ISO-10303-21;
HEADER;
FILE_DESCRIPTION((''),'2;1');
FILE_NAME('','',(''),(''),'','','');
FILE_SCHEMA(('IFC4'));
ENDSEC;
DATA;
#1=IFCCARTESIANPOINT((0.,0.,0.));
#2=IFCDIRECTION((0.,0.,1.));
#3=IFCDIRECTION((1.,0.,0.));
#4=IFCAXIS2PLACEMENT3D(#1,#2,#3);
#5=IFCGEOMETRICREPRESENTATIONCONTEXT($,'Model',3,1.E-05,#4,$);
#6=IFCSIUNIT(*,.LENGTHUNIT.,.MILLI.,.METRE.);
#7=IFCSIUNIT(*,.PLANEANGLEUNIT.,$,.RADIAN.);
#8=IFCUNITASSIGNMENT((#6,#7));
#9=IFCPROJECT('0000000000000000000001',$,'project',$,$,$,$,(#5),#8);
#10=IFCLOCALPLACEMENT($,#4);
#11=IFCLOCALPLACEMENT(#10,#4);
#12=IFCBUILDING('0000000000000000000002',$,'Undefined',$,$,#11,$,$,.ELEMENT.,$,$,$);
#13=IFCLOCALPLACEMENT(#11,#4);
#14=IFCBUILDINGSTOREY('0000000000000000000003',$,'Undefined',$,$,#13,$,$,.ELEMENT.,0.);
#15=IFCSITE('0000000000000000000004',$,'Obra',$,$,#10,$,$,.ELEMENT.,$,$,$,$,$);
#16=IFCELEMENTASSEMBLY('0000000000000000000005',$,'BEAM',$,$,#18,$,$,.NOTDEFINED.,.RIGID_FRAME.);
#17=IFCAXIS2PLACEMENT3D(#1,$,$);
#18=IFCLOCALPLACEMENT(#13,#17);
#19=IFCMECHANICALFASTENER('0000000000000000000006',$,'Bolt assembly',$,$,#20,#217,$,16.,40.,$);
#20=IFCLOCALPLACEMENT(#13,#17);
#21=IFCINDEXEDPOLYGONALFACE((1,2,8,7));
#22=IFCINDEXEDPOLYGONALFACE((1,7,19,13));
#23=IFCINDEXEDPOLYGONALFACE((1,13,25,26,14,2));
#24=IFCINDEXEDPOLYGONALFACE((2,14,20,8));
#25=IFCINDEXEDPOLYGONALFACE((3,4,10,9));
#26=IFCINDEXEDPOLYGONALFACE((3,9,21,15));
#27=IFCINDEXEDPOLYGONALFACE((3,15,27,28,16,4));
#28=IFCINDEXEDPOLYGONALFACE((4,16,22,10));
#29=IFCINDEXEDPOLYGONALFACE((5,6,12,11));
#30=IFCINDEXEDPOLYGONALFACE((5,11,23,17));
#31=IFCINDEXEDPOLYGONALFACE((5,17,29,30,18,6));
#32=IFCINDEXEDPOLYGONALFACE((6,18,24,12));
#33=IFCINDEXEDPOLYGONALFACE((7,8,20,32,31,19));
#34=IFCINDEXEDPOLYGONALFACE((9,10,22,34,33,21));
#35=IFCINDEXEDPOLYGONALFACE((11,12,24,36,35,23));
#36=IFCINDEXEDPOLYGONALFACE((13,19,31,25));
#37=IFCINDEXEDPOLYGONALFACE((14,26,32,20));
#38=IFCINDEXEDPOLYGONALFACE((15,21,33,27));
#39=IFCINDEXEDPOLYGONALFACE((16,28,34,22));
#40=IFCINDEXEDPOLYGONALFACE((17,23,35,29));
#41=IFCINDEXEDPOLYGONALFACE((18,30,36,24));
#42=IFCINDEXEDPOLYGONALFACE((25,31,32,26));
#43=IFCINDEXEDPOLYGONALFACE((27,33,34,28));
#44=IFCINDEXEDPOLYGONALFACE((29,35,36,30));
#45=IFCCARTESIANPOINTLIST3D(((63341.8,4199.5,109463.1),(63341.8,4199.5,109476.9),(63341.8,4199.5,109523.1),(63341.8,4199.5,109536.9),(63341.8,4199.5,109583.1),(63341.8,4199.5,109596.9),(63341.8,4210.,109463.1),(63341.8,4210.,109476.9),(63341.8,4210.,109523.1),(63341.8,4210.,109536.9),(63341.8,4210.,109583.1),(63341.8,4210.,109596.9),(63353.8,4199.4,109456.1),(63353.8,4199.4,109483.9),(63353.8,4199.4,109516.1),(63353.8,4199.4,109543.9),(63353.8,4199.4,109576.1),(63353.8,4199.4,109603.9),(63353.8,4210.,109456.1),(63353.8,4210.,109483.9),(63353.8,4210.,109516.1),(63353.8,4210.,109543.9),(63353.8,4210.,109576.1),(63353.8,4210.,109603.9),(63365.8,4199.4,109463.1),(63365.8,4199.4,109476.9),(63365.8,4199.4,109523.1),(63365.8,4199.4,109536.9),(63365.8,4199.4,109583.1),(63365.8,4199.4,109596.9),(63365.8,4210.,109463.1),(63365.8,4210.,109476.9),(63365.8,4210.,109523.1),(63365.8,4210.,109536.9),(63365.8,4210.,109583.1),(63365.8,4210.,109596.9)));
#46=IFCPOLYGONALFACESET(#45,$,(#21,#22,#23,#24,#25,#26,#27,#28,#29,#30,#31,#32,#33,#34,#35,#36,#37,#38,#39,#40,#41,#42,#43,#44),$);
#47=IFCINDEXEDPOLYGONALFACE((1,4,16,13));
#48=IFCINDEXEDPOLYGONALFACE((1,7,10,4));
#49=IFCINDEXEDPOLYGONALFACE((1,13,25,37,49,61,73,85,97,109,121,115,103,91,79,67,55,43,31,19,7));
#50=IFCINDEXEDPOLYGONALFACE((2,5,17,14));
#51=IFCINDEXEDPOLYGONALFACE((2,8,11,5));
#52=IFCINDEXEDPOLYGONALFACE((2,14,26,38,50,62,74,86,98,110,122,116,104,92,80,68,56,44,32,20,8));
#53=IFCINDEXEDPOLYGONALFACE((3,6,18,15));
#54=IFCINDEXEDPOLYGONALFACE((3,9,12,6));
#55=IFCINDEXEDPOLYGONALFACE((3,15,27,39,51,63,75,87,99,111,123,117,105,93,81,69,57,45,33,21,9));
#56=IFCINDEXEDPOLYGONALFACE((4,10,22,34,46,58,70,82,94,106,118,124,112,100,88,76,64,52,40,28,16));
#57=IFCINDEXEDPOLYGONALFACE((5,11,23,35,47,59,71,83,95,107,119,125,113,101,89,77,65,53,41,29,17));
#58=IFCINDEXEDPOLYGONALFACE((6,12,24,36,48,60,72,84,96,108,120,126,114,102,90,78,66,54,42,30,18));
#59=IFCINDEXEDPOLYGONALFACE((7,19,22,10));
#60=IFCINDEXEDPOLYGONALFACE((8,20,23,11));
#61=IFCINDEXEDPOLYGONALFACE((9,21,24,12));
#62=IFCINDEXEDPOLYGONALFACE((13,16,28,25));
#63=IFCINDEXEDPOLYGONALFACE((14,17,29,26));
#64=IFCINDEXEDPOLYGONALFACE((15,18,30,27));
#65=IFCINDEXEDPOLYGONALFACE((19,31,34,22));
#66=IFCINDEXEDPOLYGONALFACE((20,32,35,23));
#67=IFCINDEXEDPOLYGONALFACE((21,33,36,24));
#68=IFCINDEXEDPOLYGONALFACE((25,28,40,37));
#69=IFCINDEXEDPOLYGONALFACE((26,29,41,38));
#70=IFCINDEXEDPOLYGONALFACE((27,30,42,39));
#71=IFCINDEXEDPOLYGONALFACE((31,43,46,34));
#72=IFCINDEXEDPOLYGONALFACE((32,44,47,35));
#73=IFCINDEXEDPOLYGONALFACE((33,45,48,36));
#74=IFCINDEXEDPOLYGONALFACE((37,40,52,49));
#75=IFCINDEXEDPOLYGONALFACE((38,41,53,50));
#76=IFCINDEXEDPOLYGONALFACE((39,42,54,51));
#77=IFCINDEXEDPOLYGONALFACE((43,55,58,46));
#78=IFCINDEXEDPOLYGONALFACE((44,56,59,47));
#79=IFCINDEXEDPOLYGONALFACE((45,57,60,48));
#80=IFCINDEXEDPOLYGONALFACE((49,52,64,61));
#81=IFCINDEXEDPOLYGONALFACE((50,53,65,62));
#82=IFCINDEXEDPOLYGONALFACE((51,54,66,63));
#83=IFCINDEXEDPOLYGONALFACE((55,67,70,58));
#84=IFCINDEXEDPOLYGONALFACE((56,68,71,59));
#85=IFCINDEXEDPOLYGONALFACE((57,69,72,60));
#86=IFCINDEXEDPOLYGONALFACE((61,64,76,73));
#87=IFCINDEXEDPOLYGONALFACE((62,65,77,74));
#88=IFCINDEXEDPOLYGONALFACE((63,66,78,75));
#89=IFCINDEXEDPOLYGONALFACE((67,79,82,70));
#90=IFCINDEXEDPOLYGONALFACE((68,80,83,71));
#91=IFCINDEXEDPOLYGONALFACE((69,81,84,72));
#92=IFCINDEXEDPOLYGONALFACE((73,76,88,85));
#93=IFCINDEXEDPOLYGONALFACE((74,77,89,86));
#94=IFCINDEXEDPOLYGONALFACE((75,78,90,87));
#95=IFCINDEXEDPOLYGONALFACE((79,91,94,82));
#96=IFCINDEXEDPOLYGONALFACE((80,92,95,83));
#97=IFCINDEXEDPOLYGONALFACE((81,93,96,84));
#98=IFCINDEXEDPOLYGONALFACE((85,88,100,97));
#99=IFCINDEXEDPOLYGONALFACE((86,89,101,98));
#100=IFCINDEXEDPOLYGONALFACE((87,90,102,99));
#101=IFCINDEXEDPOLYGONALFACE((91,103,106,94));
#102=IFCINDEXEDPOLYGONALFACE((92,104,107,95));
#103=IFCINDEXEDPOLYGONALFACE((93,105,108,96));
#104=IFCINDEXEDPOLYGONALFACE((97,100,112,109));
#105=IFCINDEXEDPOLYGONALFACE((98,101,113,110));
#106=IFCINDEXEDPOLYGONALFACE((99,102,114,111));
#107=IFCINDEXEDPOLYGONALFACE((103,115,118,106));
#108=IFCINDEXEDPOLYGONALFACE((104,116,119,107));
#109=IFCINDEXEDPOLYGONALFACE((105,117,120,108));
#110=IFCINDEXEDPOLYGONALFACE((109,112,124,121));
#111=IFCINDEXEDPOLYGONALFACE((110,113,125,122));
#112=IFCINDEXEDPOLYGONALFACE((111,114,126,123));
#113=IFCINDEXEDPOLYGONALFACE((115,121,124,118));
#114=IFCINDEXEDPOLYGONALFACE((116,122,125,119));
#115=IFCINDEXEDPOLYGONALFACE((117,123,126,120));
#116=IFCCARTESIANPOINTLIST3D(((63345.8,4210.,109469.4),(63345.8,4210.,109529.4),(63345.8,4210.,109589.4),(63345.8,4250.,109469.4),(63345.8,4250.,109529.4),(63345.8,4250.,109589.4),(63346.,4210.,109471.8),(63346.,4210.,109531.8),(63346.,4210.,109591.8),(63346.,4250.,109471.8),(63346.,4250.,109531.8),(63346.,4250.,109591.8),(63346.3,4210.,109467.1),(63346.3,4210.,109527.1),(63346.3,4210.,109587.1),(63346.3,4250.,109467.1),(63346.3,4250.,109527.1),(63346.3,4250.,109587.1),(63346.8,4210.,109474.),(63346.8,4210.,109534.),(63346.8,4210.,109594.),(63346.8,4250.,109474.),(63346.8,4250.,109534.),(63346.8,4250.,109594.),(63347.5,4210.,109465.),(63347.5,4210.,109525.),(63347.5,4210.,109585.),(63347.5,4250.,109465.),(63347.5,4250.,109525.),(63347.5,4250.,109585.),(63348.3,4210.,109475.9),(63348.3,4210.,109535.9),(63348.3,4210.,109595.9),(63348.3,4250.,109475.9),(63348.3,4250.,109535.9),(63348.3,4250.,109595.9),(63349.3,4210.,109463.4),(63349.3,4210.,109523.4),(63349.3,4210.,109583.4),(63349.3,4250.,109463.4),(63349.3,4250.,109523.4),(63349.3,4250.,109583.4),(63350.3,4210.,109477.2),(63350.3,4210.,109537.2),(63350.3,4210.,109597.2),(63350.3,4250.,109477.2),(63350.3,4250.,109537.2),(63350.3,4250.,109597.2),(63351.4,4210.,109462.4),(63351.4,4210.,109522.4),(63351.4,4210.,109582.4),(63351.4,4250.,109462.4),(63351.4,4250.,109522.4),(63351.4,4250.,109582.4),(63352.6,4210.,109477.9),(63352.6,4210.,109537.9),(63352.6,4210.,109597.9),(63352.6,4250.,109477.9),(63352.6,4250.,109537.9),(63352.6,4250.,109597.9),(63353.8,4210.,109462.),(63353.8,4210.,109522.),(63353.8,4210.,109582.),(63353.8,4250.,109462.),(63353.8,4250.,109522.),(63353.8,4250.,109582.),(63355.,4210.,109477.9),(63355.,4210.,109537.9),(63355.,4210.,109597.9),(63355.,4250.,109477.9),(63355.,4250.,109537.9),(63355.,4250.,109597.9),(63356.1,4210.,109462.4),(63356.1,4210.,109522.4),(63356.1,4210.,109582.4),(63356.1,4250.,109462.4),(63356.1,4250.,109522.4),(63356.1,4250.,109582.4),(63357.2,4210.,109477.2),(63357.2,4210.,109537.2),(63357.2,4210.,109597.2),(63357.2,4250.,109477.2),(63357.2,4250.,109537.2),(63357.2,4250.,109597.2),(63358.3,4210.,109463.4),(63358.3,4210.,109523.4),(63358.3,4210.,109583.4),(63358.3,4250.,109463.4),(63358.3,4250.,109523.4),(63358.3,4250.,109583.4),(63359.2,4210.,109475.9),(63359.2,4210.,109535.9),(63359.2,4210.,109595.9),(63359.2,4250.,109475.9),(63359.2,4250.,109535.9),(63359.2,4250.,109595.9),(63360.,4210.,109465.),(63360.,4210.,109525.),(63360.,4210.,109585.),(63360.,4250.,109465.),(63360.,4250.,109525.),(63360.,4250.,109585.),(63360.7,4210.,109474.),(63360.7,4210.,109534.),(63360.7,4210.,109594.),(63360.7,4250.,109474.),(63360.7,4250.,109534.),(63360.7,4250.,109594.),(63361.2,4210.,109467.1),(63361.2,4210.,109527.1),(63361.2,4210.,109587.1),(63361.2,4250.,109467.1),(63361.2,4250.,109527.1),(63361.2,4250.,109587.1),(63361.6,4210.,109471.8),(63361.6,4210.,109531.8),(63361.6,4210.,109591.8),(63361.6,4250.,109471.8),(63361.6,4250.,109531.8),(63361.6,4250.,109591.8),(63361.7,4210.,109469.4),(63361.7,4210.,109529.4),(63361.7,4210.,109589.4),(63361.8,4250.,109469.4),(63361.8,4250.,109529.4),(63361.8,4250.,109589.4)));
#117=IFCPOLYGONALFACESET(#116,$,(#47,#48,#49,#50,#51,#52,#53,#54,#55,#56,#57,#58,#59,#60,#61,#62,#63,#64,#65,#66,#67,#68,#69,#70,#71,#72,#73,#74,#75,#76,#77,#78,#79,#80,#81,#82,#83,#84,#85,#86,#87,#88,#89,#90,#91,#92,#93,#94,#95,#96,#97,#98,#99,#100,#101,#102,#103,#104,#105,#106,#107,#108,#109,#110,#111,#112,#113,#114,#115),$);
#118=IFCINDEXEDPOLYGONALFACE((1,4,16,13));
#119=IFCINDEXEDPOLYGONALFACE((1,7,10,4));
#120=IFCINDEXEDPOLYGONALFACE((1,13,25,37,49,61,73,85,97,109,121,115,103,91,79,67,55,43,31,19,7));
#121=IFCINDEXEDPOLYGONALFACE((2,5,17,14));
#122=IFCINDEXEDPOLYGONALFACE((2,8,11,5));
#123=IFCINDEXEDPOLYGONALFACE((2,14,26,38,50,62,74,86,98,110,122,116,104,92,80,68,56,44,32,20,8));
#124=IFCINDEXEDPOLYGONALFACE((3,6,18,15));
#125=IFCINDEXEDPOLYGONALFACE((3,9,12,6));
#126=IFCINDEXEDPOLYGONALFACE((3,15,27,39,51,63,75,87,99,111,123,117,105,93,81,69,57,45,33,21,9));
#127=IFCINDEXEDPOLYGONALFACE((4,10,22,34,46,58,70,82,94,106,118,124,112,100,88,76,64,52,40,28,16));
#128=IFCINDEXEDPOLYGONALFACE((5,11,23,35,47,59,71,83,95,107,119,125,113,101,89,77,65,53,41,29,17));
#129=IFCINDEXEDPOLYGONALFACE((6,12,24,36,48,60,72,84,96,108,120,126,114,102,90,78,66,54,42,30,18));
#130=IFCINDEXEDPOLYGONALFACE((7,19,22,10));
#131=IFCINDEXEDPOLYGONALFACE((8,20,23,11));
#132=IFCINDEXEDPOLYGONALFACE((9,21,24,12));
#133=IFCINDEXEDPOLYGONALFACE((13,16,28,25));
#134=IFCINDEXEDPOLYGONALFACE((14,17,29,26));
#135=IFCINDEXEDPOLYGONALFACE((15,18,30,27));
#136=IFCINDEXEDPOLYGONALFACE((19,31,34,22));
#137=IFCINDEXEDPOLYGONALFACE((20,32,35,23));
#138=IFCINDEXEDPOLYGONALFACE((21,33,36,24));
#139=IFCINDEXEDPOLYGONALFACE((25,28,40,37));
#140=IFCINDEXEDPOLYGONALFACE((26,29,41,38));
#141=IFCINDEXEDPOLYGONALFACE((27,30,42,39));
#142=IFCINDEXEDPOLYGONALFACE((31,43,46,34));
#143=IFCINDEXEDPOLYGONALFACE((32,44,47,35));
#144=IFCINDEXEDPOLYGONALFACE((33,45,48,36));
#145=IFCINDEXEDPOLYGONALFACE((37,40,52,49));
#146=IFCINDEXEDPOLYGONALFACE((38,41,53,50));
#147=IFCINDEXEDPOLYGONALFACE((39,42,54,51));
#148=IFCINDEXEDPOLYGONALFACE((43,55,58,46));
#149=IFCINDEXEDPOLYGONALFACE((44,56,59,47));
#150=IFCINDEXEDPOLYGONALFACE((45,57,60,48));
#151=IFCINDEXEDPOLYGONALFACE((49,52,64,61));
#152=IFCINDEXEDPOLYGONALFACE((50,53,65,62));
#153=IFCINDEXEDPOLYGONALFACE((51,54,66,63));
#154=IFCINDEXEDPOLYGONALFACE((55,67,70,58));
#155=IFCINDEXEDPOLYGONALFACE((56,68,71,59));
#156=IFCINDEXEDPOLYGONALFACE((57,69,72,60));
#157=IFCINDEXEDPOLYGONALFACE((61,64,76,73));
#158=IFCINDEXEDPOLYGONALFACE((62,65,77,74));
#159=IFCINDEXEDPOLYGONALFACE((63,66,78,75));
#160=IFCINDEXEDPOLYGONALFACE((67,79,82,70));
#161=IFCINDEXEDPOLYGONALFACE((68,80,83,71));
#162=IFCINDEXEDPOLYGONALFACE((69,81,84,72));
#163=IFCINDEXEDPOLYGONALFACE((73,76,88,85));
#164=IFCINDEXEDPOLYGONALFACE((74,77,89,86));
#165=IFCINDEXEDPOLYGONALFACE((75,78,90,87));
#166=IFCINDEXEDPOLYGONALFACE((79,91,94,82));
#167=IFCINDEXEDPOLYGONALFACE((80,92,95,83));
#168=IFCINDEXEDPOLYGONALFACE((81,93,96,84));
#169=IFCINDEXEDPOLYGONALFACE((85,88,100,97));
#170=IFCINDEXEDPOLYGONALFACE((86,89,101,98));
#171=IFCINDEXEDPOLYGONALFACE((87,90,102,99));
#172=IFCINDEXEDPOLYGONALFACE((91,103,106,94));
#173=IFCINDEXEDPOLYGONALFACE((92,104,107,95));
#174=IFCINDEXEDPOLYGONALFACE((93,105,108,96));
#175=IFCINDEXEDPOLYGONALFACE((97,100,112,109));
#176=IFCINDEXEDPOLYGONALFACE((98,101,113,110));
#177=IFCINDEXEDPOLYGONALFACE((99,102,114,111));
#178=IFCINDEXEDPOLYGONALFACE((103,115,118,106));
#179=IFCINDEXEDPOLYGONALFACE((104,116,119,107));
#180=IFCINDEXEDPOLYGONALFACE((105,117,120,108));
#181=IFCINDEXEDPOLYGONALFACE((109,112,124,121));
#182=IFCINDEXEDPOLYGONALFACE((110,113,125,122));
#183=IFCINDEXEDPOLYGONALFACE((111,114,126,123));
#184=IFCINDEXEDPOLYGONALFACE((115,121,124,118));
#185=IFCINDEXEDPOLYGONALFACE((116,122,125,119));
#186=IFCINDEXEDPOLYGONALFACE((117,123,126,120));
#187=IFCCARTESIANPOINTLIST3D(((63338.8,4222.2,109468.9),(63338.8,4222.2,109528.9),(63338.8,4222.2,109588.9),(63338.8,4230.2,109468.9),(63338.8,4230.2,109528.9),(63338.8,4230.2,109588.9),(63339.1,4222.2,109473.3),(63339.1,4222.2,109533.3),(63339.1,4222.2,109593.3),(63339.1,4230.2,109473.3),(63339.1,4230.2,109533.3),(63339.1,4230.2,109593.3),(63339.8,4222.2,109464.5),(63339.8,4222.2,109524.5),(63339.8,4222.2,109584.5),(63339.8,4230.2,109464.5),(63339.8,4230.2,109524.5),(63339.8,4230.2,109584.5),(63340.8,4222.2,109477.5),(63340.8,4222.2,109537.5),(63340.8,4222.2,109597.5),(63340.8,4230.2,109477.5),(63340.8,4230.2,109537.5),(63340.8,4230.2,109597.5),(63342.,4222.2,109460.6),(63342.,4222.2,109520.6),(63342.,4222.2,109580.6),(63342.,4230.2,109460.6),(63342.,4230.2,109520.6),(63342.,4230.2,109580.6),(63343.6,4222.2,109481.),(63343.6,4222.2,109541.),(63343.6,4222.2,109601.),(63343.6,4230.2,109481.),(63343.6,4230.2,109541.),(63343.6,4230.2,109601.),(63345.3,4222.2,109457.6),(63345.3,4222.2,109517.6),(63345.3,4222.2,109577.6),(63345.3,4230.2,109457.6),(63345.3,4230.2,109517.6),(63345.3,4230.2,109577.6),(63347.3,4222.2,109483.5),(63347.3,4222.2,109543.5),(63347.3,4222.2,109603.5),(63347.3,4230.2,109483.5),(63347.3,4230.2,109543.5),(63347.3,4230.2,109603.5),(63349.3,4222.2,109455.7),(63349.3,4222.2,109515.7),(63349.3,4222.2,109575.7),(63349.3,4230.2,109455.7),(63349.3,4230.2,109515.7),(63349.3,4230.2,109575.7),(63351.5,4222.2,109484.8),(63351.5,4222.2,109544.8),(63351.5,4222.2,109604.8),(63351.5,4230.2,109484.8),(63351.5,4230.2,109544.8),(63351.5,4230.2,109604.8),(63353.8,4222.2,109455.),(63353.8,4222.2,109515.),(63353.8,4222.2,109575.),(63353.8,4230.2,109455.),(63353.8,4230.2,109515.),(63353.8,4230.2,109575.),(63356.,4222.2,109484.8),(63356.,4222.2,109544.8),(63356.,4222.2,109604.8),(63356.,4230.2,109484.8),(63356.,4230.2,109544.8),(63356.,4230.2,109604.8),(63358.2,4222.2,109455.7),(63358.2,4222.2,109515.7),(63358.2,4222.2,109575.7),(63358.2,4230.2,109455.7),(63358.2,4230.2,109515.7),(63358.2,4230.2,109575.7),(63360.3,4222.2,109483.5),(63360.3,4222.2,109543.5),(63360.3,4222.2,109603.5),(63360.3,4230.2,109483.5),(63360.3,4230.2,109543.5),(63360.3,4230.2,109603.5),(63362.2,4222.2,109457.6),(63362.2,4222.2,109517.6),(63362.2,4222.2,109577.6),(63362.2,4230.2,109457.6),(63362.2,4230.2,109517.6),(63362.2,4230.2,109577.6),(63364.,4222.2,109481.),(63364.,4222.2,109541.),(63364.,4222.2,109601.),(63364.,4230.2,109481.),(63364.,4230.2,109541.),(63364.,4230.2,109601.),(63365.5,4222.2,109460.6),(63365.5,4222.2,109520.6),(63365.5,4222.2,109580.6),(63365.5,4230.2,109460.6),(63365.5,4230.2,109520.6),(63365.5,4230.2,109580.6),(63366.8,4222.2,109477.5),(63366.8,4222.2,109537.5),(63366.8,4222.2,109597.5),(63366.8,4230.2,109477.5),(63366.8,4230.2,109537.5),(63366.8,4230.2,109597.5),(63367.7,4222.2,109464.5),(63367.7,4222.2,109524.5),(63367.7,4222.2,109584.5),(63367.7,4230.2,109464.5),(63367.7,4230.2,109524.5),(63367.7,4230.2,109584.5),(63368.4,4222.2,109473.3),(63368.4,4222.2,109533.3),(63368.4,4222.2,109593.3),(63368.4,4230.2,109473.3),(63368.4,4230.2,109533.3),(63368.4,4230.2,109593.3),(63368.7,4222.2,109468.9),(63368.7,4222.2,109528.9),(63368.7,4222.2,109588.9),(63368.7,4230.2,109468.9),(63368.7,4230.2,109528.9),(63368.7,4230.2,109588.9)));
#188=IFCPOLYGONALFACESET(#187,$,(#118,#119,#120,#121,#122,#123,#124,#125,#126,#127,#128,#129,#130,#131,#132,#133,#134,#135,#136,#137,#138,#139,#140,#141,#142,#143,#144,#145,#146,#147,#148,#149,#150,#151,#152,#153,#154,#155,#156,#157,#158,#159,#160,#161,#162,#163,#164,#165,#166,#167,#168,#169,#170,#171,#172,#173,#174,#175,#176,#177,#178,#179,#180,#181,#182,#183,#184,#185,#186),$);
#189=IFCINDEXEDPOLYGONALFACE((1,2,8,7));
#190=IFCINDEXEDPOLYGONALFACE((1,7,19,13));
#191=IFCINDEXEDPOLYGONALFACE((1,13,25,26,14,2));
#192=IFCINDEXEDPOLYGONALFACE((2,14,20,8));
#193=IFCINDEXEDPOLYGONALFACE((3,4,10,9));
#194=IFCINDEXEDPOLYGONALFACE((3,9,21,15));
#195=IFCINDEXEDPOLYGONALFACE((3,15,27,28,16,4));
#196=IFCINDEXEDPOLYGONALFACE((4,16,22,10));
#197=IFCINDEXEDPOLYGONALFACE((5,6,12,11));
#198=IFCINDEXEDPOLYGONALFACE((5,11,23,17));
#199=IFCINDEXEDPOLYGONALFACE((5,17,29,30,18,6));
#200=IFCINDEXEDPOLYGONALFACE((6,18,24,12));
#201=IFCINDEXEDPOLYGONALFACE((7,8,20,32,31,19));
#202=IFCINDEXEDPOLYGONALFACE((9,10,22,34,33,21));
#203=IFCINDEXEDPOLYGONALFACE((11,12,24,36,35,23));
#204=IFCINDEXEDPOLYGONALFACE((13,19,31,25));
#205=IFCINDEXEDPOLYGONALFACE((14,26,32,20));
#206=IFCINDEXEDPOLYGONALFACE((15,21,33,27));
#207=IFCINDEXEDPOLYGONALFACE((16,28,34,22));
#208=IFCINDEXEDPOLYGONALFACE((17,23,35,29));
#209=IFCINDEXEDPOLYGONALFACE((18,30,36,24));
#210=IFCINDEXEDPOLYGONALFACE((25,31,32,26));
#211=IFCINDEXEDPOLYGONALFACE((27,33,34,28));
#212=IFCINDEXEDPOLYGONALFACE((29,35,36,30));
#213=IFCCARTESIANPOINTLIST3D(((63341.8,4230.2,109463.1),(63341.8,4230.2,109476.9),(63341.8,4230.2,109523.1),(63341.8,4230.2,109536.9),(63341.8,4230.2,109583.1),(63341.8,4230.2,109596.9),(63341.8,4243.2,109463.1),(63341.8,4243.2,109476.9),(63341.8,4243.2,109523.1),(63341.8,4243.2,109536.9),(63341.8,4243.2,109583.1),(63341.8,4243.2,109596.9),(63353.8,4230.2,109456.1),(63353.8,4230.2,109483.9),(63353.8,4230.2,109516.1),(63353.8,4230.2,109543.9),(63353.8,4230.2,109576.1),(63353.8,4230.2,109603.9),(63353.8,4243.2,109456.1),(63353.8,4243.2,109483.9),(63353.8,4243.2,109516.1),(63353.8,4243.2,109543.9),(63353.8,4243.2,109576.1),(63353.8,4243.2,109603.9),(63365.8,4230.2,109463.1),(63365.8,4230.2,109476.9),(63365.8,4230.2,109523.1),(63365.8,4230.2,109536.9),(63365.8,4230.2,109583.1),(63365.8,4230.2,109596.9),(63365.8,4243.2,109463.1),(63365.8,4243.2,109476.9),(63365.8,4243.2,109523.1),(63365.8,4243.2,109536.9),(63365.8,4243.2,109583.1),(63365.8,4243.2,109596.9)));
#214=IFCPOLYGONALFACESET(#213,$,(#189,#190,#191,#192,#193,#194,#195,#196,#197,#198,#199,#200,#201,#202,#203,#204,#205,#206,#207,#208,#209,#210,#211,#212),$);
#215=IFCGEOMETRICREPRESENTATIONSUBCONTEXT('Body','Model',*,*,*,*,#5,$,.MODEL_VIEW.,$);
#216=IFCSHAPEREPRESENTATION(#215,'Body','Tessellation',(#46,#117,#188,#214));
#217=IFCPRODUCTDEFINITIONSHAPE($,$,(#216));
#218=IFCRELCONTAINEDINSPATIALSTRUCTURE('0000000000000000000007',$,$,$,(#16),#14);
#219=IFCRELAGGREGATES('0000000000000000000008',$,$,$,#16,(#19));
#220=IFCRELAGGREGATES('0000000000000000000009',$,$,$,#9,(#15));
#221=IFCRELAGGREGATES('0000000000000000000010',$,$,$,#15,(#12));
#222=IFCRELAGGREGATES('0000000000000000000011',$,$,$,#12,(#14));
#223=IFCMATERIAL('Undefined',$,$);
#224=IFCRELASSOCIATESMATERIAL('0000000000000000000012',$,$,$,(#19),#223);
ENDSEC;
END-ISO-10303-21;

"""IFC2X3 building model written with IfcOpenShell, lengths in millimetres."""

from ifc_helpers import new_model, si_unit, frame, origin_with_axes, origin_2d_with_axis, place, context, subcontext, project, spatial, polyline, circle, outline, extrude, source, transform, mapped, material, element, aggregate, save


model = new_model("IFC2X3")

# Units and contexts
model_context = context("Model", 3, precision=1e-05, world=origin_with_axes())
body_context = subcontext(model_context, "Body", "Model", "MODEL_VIEW")
ifc_project = project(units=[si_unit("LENGTHUNIT", "METRE", prefix="MILLI"), si_unit("PLANEANGLEUNIT", "RADIAN")], contexts=[model_context])

# Site, building, storey
site_placement = place(None, origin_with_axes())
site = spatial("IfcSite", under=ifc_project, at=site_placement, Name="Obra", CompositionType="ELEMENT")
building_placement = place(site_placement, origin_with_axes())
building = spatial("IfcBuilding", under=site, at=building_placement, Name="Undefined", CompositionType="ELEMENT")
storey_placement = place(building_placement, origin_with_axes())
storey = spatial("IfcBuildingStorey", under=building, at=storey_placement, Name="Undefined", CompositionType="ELEMENT", Elevation=0.0)

# Element assembly
assembly_1_placement = place(storey_placement, origin_with_axes())
assembly_1 = element("IfcElementAssembly", 1, at=assembly_1_placement, inside=storey, Name="BEAM", AssemblyPlace="NOTDEFINED", PredefinedType="RIGID_FRAME")

# Mechanical fastener
ifc_material_1 = material(Name="Undefined")
shared_shape_1 = source(origin_with_axes(), body_context, "Body", "SweptSolid", [
    extrude(outline(polyline([(13.9, 0.0), (6.9, 12.0), (-6.9, 12.0), (-13.9, 0.0), (-6.9, -12.0), (6.9, -12.0), (13.9, 0.0)])), frame((0.0, -19.7, 0.0), z_axis=(0.0, 1.0, 0.0), x_axis=(1.0, 0.0, 0.0)), (0.0, 0.0, 1.0), 10.6),
    extrude(circle(Radius=8.0, at=origin_2d_with_axis()), frame((0.0, -9.1, 0.0), z_axis=(0.0, 1.0, 0.0), x_axis=(1.0, 0.0, 0.0)), (0.0, 0.0, 1.0), 40.0),
    extrude(circle(Radius=15.0, at=origin_2d_with_axis()), frame((0.0, 3.1, 0.0), z_axis=(0.0, 1.0, 0.0), x_axis=(1.0, 0.0, 0.0)), (0.0, 0.0, 1.0), 8.0),
    extrude(outline(polyline([(13.9, 0.0), (6.9, 12.0), (-6.9, 12.0), (-13.9, 0.0), (-6.9, -12.0), (6.9, -12.0), (13.9, 0.0)])), frame((0.0, 11.1, 0.0), z_axis=(0.0, 1.0, 0.0), x_axis=(1.0, 0.0, 0.0)), (0.0, 0.0, 1.0), 13.0),
])
mechanical_fastener_1_placement = place(assembly_1_placement, frame((63303.8, 4219.1, 109650.0), z_axis=(1.0, -0.000126, 0.0), x_axis=(0.0, 0.0, -1.0)))
mechanical_fastener_1 = element("IfcMechanicalFastener", 2, at=mechanical_fastener_1_placement, material=ifc_material_1, Name="Bolt assembly", NominalDiameter=16.0, NominalLength=40.0, context=body_context, shape_type="MappedRepresentation", body=[
    mapped(shared_shape_1, transform((60.0, 0.0, 50.0))),
    mapped(shared_shape_1, transform((120.0, 0.0, 50.0))),
    mapped(shared_shape_1, transform((180.0, 0.0, 50.0))),
])
aggregate(assembly_1, [mechanical_fastener_1])

save(model, "model.ifc")
